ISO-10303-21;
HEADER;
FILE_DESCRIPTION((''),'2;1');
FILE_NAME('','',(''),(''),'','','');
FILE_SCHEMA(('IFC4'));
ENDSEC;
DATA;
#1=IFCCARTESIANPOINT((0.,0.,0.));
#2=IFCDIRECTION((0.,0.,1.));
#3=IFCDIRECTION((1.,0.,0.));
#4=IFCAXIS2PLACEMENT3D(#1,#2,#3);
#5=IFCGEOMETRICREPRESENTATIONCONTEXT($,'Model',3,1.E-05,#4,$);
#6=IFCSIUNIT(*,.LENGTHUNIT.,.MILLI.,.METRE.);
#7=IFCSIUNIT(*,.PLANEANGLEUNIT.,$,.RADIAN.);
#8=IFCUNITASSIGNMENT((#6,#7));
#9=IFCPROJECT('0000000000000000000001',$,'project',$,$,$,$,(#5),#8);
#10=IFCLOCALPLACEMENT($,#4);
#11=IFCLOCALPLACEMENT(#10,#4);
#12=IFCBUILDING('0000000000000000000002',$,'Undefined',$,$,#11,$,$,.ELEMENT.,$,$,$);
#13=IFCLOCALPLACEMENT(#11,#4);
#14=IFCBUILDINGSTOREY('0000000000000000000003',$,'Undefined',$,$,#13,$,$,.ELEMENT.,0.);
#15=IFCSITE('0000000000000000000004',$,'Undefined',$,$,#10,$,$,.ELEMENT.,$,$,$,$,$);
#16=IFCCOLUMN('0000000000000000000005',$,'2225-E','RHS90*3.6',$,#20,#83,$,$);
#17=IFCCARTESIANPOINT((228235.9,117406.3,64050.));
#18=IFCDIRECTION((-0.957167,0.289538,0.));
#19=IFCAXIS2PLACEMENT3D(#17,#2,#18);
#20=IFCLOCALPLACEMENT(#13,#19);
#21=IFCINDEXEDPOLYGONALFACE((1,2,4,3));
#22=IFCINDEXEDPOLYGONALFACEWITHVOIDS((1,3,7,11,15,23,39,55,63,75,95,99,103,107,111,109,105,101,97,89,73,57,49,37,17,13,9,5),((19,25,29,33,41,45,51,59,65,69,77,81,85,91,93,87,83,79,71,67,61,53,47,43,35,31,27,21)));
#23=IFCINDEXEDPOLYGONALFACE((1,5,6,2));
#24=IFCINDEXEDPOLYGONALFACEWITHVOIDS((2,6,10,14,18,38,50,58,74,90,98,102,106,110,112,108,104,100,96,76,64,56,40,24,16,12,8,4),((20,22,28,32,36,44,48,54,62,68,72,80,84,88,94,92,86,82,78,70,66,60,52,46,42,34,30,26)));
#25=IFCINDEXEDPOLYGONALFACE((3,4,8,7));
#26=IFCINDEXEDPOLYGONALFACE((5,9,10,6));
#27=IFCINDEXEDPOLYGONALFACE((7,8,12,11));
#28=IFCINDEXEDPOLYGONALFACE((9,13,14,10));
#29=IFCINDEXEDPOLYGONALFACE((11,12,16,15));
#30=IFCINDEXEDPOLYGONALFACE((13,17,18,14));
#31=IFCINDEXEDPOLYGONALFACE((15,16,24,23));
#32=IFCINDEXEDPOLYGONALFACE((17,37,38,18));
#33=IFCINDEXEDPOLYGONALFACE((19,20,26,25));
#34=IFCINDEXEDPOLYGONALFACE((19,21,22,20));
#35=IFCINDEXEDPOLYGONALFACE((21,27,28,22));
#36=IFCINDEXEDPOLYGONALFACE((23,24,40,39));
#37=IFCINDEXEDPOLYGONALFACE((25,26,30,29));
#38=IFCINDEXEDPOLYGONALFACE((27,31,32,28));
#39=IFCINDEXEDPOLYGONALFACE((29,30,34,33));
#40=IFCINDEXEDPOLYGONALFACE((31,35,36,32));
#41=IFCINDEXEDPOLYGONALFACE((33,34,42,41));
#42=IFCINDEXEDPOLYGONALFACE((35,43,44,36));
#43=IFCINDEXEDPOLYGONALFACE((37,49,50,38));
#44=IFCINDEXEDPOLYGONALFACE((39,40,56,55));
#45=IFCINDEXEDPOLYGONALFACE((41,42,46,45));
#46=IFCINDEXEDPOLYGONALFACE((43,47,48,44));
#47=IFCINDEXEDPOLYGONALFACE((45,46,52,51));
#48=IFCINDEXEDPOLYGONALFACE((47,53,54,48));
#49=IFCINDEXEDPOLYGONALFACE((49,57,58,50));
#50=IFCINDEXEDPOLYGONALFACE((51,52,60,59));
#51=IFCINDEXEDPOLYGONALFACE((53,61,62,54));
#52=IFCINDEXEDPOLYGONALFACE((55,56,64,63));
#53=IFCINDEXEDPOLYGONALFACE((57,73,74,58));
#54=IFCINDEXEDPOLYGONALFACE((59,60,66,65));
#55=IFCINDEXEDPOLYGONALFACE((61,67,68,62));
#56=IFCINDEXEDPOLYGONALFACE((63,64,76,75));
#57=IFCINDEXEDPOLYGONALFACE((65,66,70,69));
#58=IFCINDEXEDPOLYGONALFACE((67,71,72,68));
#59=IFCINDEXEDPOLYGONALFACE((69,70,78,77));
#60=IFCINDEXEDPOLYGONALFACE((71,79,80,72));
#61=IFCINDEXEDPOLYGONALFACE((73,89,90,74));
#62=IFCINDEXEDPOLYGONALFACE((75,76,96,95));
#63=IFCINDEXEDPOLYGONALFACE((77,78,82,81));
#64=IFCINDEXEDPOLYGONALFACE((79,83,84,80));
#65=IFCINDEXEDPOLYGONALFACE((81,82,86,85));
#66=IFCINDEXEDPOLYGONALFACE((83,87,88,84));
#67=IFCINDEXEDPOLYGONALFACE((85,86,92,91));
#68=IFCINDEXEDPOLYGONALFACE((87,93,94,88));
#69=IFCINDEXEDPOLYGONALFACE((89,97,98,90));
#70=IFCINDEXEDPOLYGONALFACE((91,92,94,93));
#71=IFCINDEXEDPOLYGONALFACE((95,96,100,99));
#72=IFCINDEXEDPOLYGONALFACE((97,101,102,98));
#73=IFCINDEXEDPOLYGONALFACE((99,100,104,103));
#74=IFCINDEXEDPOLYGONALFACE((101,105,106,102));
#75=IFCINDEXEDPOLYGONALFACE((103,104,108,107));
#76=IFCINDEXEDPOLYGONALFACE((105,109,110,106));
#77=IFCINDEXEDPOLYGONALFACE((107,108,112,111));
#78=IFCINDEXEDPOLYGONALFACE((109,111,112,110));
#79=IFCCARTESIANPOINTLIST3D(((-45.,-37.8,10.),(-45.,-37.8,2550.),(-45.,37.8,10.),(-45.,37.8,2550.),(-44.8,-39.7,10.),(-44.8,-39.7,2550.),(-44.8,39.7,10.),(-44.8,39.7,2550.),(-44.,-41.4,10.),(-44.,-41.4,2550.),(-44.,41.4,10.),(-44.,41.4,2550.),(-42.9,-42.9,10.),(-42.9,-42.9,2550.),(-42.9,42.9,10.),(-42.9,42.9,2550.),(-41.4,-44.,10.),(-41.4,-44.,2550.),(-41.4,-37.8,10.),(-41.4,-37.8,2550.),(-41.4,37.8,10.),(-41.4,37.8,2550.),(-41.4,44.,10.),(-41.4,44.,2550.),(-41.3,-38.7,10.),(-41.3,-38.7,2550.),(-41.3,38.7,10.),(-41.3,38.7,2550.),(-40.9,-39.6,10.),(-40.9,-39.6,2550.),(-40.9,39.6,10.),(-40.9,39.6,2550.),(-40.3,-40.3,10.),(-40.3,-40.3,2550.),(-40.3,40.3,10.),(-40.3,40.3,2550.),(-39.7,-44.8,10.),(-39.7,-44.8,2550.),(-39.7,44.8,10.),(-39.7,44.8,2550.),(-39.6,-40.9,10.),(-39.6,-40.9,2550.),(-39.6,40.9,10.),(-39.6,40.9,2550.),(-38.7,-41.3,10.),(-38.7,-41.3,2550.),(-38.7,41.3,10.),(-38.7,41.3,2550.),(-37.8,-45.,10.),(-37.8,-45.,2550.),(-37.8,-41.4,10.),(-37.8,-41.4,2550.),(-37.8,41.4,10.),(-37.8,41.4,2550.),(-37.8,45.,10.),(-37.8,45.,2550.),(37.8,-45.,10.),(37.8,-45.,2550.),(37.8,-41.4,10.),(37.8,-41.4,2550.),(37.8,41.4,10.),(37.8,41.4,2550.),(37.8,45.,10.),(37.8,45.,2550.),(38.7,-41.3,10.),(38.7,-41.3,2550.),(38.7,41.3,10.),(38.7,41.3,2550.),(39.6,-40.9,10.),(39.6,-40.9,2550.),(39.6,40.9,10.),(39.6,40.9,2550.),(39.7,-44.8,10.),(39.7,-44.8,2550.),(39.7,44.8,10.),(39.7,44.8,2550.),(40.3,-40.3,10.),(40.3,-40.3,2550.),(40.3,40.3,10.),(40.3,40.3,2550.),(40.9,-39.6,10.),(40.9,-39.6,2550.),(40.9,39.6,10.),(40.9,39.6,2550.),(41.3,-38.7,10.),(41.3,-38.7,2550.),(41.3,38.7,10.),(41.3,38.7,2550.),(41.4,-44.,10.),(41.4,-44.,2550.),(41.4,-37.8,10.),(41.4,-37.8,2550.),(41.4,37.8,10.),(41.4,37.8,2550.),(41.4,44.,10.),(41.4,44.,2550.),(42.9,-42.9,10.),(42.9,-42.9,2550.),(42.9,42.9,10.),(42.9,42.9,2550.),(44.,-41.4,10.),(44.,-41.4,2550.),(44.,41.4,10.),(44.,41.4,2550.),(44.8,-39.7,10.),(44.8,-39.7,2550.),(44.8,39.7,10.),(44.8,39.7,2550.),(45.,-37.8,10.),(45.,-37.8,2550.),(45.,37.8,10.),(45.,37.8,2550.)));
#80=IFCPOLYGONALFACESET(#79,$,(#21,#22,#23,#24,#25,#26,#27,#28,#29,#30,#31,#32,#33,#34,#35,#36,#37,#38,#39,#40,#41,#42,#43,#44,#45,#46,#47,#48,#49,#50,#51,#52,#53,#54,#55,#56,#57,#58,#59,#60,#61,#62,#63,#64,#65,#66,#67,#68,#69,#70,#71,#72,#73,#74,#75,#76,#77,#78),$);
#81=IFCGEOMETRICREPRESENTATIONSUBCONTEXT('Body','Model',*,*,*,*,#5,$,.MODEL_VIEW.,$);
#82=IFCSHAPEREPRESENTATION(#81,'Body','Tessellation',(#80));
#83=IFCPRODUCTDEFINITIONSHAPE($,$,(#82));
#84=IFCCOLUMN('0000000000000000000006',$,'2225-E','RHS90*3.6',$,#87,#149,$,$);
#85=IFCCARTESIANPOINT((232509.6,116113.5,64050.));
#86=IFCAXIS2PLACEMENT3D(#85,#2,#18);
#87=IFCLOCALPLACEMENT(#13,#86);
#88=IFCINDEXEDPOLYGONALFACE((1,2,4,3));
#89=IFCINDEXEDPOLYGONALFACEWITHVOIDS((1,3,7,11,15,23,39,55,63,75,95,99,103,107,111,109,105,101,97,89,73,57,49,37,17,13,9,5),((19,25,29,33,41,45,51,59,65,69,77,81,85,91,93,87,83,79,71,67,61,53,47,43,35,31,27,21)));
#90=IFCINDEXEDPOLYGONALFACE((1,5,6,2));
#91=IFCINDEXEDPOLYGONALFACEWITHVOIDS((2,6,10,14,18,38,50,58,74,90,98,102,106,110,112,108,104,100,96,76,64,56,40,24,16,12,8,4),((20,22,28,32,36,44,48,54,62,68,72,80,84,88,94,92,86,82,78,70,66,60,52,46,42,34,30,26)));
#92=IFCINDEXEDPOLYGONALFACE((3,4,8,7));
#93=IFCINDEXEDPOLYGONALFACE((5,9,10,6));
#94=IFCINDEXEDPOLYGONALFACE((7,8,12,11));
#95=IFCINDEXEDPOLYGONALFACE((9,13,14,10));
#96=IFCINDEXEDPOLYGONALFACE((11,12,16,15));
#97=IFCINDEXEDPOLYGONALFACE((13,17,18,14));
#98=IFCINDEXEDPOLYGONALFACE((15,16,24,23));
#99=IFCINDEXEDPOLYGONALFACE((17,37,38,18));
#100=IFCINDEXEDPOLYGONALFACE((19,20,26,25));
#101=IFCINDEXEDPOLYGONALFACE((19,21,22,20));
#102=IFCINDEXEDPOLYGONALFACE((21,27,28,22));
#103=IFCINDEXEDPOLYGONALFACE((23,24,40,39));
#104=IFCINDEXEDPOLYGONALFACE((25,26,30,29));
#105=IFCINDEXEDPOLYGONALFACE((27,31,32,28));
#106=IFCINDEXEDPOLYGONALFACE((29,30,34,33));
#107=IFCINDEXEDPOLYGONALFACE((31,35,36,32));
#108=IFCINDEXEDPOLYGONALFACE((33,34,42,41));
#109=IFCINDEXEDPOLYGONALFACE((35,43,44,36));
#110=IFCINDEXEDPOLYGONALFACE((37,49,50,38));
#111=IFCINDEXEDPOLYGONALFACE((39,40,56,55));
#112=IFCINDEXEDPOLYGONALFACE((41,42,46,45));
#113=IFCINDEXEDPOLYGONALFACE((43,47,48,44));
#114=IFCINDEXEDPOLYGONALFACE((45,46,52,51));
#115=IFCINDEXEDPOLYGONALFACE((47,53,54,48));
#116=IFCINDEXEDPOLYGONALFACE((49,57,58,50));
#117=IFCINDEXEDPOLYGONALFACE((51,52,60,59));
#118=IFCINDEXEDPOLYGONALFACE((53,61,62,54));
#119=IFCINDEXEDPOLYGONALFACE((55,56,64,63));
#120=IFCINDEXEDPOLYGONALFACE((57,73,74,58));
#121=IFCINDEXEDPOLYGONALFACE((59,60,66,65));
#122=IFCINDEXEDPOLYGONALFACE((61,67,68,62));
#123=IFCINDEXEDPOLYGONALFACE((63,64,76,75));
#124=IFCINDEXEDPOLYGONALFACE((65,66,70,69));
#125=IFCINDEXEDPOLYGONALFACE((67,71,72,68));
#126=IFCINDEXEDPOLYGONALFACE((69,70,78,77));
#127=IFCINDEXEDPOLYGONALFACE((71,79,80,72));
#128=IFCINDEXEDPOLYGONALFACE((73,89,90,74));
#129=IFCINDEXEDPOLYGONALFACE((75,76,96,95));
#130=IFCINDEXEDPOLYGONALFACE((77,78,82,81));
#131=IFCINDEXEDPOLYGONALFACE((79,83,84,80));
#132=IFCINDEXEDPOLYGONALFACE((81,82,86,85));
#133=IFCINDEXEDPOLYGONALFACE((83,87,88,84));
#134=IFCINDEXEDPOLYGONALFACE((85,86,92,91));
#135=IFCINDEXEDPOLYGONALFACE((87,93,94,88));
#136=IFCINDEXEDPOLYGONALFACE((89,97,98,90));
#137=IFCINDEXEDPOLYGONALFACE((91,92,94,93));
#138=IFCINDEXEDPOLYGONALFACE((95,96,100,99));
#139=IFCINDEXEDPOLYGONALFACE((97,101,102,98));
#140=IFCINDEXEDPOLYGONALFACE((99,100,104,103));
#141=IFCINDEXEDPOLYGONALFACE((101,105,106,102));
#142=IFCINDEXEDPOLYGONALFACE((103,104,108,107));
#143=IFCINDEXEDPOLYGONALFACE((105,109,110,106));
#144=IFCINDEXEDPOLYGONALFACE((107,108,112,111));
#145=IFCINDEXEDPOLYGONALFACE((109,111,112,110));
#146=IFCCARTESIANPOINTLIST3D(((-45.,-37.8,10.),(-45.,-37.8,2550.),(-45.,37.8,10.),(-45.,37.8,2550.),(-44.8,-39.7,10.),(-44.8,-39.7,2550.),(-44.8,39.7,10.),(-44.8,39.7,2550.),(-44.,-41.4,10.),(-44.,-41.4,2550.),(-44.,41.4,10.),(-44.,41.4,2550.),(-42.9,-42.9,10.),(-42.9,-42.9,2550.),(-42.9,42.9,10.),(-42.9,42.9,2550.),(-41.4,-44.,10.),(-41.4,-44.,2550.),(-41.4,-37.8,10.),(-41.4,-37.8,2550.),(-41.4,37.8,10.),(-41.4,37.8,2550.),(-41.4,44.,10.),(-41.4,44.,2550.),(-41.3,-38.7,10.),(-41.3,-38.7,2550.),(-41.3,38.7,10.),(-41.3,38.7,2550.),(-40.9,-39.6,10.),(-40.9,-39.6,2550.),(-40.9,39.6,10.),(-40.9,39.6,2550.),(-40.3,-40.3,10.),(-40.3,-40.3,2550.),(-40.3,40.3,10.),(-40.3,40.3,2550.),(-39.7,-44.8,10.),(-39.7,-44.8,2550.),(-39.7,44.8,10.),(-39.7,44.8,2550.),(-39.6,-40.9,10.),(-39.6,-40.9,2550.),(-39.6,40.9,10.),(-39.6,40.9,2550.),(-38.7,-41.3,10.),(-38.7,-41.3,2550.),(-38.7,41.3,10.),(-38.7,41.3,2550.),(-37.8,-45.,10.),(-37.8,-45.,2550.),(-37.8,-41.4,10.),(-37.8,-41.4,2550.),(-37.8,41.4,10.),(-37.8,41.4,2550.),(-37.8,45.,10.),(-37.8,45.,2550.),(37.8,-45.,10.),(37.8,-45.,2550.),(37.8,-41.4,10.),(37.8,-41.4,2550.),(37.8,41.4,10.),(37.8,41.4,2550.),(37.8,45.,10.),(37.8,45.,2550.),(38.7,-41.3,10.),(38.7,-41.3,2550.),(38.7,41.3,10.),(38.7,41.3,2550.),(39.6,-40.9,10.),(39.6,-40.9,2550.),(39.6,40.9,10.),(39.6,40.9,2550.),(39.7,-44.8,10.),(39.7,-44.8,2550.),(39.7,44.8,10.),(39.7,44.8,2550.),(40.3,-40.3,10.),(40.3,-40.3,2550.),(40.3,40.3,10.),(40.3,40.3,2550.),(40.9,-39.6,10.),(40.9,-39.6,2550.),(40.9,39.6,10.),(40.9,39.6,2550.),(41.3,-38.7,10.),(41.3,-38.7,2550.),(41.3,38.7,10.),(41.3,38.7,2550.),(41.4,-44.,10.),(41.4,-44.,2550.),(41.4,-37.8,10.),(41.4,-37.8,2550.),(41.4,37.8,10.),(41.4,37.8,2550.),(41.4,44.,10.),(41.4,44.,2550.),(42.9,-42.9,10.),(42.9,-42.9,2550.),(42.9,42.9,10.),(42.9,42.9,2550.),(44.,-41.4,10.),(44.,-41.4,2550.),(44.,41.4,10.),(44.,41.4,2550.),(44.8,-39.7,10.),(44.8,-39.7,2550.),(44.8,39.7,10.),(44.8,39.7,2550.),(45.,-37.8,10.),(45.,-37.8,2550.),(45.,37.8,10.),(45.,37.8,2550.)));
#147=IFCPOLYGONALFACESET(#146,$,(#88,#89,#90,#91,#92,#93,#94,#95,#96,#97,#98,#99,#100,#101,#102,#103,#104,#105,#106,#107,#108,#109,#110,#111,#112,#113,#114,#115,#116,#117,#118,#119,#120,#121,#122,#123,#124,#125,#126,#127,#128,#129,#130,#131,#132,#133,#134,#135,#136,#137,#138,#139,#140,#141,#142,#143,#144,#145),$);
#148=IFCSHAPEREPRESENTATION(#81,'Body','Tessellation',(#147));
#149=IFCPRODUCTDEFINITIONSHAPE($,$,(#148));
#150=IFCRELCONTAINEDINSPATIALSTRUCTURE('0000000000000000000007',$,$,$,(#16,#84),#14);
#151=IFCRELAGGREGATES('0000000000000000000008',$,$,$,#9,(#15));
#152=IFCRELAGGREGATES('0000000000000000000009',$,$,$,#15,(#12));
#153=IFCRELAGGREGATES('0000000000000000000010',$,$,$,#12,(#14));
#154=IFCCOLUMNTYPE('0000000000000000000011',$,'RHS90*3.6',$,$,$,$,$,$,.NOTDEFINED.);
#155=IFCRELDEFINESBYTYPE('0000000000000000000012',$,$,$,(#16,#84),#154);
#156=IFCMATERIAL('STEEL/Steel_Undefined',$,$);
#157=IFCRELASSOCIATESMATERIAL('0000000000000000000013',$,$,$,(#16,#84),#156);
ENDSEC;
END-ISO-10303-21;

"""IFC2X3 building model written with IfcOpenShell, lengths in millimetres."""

from ifc_helpers import new_model, si_unit, frame, origin_with_axes, origin_2d_with_axis, place, context, subcontext, project, spatial, hollow_rectangle, extrude, clip, halfspace, material, type_object, element, save


model = new_model("IFC2X3")

# Units and contexts
model_context = context("Model", 3, precision=1e-05, world=origin_with_axes())
body_context = subcontext(model_context, "Body", "Model", "MODEL_VIEW")
ifc_project = project(units=[si_unit("LENGTHUNIT", "METRE", prefix="MILLI"), si_unit("PLANEANGLEUNIT", "RADIAN")], contexts=[model_context])

# Site, building, storey
site_placement = place(None, origin_with_axes())
site = spatial("IfcSite", under=ifc_project, at=site_placement, Name="Undefined", CompositionType="ELEMENT")
building_placement = place(site_placement, origin_with_axes())
building = spatial("IfcBuilding", under=site, at=building_placement, Name="Undefined", CompositionType="ELEMENT")
storey_placement = place(building_placement, origin_with_axes())
storey = spatial("IfcBuildingStorey", under=building, at=storey_placement, Name="Undefined", CompositionType="ELEMENT", Elevation=0.0)

# Columns
ifc_material_1 = material(Name="STEEL/Steel_Undefined")
column_type = type_object("IfcColumnType", Name="RHS90*3.6", PredefinedType="NOTDEFINED")
for number, where, z_axis, x_axis, name in (
    (1, (228235.9, 117406.3, 64050.0), (0.0, 0.0, 1.0), (-0.957167, 0.289538, 0.0), "2225-E"),
    (2, (232509.6, 116113.5, 64050.0), (0.0, 0.0, 1.0), (-0.957167, 0.289538, 0.0), "2225-E"),
):
    element("IfcColumn", number, at=place(storey_placement, frame(where, z_axis=z_axis, x_axis=x_axis)), inside=storey, type_object=column_type, material=ifc_material_1, Name=name, Description="RHS90*3.6", context=body_context, shape_type="Clipping", body=[
        clip(extrude(hollow_rectangle(XDim=90.0, YDim=90.0, WallThickness=3.6, InnerFilletRadius=3.6, OuterFilletRadius=7.2, at=origin_2d_with_axis()), frame((0.0, 0.0, 2550.0), z_axis=(0.0, 0.0, -1.0), x_axis=(0.0, 1.0, 0.0)), (0.0, 0.0, 1.0), 2550.0), halfspace(frame((-45.0, 0.0, 10.0), z_axis=(0.0, 0.0, 1.0), x_axis=(0.0, 1.0, 0.0)), True)),
    ])

save(model, "model.ifc")
